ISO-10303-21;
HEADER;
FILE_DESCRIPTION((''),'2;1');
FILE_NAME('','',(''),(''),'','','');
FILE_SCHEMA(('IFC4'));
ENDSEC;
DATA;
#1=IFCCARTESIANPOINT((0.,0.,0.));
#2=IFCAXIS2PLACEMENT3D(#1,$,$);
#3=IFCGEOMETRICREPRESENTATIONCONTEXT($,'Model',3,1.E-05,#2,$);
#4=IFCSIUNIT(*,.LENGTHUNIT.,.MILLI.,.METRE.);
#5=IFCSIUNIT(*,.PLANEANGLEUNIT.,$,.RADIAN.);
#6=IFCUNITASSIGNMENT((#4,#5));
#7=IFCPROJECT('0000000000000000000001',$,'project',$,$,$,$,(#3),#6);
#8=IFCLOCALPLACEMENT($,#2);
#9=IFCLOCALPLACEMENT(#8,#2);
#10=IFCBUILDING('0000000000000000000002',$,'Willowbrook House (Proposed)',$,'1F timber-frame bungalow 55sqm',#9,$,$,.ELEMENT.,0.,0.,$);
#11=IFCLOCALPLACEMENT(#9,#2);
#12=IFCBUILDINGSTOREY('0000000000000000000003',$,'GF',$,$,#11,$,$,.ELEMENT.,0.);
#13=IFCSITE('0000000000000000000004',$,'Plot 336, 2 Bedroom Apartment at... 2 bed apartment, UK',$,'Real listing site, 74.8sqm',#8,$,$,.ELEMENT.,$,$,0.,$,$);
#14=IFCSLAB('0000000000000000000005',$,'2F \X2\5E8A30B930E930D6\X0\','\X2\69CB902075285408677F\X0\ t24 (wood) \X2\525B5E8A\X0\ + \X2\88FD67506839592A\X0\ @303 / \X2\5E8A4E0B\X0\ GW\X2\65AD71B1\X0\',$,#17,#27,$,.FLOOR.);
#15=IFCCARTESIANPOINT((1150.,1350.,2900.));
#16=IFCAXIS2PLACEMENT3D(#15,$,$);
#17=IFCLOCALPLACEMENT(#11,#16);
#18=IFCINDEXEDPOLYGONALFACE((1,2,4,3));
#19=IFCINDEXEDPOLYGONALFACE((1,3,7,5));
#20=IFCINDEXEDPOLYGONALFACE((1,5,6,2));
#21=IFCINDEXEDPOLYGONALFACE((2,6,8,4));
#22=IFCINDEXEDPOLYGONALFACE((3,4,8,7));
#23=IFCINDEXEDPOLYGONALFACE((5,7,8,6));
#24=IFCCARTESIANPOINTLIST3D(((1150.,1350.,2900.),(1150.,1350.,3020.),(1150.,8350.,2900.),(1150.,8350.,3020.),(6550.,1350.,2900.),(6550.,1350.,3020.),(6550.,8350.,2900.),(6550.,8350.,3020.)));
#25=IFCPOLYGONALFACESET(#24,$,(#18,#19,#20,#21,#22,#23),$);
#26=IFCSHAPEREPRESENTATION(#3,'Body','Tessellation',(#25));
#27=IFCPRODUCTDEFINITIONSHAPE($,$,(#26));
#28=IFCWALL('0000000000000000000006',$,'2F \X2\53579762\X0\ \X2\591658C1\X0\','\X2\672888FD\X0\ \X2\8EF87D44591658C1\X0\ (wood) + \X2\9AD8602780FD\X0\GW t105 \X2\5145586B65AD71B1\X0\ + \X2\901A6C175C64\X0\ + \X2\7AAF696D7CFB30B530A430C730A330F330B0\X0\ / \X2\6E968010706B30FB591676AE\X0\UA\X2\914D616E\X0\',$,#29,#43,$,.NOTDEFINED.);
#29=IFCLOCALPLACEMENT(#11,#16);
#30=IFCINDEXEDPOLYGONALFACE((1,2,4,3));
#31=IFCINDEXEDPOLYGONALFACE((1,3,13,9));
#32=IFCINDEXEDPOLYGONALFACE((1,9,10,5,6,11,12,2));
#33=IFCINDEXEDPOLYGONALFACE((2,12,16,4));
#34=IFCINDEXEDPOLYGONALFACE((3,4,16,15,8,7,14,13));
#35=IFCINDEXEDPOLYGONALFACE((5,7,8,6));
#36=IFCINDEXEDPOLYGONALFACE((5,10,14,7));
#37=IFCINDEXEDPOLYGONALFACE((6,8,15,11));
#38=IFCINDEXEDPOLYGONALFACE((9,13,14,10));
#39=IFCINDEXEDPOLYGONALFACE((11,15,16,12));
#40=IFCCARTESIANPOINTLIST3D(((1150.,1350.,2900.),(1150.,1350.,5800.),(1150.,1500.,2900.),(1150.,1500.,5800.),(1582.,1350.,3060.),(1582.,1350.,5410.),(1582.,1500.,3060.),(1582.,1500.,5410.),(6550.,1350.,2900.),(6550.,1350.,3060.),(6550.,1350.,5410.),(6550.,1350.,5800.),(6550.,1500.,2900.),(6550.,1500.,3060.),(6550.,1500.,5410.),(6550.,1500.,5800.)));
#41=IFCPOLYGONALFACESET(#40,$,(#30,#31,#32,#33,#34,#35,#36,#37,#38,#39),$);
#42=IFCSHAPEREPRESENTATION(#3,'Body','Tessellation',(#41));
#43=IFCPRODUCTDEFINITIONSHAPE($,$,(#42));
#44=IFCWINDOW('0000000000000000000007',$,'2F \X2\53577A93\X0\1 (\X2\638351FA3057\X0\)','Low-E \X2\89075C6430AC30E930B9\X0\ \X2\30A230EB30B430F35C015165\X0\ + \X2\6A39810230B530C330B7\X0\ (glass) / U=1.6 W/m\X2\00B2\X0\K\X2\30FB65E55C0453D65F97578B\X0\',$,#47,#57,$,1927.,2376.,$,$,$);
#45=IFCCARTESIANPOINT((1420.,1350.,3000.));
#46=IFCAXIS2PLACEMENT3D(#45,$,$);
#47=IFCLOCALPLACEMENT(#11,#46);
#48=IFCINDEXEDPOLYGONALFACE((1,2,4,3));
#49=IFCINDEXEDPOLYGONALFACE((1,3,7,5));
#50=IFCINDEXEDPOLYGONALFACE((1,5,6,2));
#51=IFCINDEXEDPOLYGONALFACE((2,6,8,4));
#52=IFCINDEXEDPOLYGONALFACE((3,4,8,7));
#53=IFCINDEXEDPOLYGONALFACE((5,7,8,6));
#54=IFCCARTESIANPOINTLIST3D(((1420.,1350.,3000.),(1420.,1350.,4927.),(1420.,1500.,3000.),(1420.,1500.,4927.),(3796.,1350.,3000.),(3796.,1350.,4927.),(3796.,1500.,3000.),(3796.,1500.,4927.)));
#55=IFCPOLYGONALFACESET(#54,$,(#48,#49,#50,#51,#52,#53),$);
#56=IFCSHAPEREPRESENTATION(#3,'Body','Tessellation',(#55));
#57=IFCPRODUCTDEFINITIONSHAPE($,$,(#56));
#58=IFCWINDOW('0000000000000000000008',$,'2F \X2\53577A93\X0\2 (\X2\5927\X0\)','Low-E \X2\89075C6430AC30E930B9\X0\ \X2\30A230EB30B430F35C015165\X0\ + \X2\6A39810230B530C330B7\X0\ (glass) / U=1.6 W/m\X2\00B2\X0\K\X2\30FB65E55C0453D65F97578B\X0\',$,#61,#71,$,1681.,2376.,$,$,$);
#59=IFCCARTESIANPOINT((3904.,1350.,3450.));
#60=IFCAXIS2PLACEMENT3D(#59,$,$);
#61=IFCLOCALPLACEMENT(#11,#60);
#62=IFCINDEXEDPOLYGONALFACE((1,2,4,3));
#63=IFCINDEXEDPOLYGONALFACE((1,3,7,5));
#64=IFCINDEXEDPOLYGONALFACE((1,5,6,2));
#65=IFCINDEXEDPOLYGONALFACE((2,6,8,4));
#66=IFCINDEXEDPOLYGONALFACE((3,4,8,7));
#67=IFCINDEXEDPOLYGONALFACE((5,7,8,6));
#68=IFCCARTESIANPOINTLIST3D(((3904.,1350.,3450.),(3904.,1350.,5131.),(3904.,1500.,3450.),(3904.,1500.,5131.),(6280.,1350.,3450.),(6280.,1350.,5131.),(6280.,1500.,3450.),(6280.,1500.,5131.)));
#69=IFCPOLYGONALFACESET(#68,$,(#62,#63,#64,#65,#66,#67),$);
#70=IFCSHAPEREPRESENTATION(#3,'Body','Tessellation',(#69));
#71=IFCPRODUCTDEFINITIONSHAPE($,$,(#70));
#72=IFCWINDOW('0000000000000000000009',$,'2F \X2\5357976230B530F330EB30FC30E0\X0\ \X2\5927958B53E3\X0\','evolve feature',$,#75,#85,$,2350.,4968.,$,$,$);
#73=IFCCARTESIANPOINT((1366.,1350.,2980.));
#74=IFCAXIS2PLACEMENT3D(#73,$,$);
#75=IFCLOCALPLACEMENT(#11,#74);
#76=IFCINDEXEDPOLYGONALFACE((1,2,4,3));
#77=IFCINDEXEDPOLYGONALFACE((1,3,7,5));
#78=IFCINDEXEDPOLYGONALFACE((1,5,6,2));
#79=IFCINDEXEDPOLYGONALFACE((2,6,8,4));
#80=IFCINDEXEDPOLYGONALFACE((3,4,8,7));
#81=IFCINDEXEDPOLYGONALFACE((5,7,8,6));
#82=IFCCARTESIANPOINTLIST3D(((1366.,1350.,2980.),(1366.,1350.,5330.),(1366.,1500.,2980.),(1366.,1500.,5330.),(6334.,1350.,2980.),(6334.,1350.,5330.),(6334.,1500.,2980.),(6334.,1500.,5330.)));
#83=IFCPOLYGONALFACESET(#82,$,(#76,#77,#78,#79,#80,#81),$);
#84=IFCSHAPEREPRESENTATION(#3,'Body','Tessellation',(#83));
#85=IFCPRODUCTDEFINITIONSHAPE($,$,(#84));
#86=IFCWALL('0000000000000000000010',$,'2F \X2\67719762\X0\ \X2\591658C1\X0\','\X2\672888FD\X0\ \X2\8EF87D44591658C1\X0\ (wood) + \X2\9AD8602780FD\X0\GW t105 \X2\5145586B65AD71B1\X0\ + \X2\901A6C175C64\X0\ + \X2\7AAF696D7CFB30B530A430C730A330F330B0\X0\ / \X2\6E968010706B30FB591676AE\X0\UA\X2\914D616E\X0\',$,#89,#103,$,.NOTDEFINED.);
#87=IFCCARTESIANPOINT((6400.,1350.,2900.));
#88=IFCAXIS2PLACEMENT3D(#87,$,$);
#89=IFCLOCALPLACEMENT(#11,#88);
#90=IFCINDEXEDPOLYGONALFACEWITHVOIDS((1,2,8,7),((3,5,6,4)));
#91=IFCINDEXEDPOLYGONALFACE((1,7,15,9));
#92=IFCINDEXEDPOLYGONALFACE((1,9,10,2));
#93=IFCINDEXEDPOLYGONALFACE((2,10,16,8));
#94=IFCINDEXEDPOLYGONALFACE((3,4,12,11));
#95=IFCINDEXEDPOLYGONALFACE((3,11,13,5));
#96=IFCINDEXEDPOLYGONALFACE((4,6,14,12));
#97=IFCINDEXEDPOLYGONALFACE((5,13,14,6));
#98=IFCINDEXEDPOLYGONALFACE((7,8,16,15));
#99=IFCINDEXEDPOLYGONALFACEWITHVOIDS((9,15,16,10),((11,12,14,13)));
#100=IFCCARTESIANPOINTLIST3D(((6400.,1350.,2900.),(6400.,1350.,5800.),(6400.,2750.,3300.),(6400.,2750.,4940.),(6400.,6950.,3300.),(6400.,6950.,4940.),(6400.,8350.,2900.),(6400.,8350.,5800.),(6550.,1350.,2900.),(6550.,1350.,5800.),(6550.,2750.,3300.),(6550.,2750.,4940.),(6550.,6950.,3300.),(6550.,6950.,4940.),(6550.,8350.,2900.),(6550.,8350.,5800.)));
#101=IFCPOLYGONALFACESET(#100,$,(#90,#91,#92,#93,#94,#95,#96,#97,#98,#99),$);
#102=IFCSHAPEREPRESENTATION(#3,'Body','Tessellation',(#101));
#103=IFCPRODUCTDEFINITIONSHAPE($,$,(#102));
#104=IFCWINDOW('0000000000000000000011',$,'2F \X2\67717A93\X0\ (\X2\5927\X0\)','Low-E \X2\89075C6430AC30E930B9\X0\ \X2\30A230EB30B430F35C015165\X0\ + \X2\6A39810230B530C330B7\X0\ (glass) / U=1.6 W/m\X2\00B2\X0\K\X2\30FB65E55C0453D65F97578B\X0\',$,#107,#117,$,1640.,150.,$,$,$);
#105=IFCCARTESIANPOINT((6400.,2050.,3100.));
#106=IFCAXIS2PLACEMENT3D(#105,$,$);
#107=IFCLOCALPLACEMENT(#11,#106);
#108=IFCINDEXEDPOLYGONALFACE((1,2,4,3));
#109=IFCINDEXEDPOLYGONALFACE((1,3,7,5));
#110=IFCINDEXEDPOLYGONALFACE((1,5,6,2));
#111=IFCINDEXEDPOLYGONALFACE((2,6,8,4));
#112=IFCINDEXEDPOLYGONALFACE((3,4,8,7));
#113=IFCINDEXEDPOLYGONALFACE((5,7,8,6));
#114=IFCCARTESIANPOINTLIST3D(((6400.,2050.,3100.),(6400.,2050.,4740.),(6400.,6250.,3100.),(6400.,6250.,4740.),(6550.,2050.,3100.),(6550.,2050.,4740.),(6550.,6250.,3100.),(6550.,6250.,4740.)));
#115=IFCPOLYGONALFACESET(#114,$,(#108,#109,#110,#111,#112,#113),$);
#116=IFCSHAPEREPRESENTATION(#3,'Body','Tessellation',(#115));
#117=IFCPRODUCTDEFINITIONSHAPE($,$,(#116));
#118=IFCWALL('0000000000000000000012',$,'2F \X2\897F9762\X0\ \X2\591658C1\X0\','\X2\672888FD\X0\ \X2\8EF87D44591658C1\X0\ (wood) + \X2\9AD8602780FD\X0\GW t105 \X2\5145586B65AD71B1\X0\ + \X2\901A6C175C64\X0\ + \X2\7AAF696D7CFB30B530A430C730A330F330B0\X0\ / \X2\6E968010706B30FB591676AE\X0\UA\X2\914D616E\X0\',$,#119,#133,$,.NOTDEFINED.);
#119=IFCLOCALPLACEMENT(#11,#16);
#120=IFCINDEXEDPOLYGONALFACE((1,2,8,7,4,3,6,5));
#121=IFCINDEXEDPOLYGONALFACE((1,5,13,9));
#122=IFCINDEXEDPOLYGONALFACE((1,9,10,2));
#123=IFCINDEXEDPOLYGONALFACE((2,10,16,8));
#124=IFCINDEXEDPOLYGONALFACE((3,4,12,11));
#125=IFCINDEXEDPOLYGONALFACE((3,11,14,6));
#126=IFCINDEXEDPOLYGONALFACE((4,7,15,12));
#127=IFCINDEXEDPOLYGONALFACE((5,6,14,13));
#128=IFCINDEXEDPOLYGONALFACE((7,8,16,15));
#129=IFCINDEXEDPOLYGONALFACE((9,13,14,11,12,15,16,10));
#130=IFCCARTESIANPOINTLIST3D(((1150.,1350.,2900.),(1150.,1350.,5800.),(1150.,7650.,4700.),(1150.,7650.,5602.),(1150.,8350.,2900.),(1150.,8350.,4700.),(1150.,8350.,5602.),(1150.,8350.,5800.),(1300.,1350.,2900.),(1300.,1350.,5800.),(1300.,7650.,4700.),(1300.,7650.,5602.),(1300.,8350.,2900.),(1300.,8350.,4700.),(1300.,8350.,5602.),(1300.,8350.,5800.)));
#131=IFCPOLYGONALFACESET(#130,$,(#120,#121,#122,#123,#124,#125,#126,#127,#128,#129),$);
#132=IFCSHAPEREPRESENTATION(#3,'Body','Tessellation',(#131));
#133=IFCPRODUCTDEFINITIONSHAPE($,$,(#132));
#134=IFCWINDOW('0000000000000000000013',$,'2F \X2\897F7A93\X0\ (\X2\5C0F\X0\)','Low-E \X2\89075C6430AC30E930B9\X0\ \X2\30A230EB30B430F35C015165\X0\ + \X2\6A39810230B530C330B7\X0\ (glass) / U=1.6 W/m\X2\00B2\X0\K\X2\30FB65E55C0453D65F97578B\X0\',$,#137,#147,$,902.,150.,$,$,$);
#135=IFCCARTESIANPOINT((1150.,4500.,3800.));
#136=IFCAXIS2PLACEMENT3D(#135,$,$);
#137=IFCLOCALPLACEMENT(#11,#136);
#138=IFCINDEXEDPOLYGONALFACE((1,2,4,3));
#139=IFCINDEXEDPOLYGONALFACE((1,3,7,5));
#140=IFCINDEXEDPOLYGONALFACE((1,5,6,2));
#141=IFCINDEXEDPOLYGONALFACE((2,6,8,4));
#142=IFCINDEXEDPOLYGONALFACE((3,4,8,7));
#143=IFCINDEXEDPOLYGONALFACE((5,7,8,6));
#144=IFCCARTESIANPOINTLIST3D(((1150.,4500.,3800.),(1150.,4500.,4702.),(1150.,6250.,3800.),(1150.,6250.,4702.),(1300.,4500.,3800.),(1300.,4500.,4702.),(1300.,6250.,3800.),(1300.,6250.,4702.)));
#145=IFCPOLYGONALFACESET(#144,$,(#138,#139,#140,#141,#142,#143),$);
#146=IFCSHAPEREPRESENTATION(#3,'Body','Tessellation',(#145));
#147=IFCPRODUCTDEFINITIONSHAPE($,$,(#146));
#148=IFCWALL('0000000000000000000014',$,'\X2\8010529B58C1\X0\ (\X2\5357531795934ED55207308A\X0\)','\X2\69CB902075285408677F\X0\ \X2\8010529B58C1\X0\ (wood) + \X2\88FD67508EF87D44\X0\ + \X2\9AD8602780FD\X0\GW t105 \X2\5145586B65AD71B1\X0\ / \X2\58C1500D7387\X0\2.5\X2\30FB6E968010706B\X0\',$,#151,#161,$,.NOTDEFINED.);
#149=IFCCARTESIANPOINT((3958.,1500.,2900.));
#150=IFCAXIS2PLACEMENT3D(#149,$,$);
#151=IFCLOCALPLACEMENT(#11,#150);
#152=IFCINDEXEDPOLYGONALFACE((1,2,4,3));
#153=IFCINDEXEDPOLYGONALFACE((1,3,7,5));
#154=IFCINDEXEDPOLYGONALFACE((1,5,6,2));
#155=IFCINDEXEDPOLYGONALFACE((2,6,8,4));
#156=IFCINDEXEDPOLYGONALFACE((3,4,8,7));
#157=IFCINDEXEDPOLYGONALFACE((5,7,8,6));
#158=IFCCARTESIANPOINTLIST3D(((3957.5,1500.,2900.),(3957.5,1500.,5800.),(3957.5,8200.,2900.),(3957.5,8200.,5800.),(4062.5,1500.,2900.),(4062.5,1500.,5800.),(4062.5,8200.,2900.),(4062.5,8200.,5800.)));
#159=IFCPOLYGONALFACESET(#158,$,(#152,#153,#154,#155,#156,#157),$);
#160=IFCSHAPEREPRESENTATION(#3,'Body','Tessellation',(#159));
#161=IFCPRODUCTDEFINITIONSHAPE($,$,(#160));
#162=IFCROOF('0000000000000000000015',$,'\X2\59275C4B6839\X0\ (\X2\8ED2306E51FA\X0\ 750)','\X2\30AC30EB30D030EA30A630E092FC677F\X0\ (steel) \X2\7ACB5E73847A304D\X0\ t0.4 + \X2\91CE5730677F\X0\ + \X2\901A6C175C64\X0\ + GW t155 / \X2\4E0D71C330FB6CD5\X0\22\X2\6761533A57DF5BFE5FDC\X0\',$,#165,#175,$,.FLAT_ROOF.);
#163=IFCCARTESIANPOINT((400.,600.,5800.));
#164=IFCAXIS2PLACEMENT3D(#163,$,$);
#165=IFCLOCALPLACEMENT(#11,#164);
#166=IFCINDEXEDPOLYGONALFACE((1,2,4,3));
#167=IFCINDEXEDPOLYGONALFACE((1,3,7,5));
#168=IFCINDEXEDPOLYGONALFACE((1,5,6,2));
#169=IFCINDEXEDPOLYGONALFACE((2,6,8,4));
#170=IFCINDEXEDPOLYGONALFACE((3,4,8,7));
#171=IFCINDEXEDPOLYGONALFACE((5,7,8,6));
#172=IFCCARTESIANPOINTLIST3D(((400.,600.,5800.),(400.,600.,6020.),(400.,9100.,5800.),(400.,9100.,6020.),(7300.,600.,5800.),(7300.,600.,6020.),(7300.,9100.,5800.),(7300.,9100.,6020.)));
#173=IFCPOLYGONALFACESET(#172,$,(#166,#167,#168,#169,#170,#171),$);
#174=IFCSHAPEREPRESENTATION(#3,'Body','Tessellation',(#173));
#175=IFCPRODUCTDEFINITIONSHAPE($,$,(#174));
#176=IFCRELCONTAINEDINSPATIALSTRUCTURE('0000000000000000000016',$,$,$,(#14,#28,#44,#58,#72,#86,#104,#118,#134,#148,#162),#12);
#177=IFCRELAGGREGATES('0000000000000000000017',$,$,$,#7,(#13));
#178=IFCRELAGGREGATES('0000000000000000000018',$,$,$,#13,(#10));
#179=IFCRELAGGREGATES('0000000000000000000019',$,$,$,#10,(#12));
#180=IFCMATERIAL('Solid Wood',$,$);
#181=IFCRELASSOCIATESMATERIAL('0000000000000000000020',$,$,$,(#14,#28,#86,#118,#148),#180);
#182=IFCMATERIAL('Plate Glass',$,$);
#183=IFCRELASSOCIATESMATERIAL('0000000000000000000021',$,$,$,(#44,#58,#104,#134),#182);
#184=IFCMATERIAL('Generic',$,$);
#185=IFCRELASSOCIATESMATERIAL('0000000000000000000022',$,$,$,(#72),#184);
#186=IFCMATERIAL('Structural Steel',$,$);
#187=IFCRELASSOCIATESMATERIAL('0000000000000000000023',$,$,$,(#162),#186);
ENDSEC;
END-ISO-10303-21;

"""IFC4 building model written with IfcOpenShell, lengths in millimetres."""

from ifc_helpers import new_model, si_unit, frame, frame_2d, origin, place, context, project, spatial, rectangle, extrude, material, element, fill, save


model = new_model("IFC4")

# Units and contexts
model_context = context("Model", 3, precision=1e-05, world=origin())
ifc_project = project(units=[si_unit("LENGTHUNIT", "METRE", prefix="MILLI"), si_unit("PLANEANGLEUNIT", "RADIAN")], contexts=[model_context])

# Site, building, storey
site_placement = place(None, origin())
site = spatial("IfcSite", under=ifc_project, at=site_placement, Name="Plot 336, 2 Bedroom Apartment at... 2 bed apartment, UK", ObjectType="Real listing site, 74.8sqm", CompositionType="ELEMENT", RefElevation=0.0)
building_placement = place(site_placement, origin())
building = spatial("IfcBuilding", under=site, at=building_placement, Name="Willowbrook House (Proposed)", ObjectType="1F timber-frame bungalow 55sqm", CompositionType="ELEMENT", ElevationOfRefHeight=0.0, ElevationOfTerrain=0.0)
storey_placement = place(building_placement, origin())
storey = spatial("IfcBuildingStorey", under=building, at=storey_placement, Name="GF", CompositionType="ELEMENT", Elevation=0.0)

# Slab
ifc_material_1 = material(Name="Solid Wood")
slab_placement = place(storey_placement, frame((1150.0, 1350.0, 2900.0)))
element("IfcSlab", 1, at=slab_placement, inside=storey, material=ifc_material_1, Name="2F 床スラブ", Description="構造用合板 t24 (wood) 剛床 + 製材根太 @303 / 床下 GW断熱", PredefinedType="FLOOR", context=model_context, shape_type="SweptSolid", body=[
    extrude(rectangle(XDim=5400.0, YDim=7000.0, at=frame_2d((2700.0, 3500.0))), frame((1150.0, 1350.0, 2900.0)), (0.0, 0.0, 1.0), 120.0),
])

# Wall, openings, windows
wall_1_placement = place(storey_placement, frame((1150.0, 1350.0, 2900.0)))
wall_1 = element("IfcWall", 2, at=wall_1_placement, inside=storey, material=ifc_material_1, Name="2F 南面 外壁", Description="木製 軸組外壁 (wood) + 高性能GW t105 充填断熱 + 通気層 + 窯業系サイディング / 準耐火・外皮UA配慮", PredefinedType="NOTDEFINED", context=model_context, shape_type="SweptSolid", body=[
    extrude(rectangle(XDim=5400.0, YDim=150.0, at=frame_2d((2700.0, 75.0))), frame((1150.0, 1350.0, 2900.0)), (0.0, 0.0, 1.0), 2900.0),
])
opening_1_placement = place(storey_placement, frame((1420.0, 1350.0, 3000.0)))
opening_1 = element("IfcOpeningElement", 3, at=opening_1_placement, cuts=wall_1, PredefinedType="NOTDEFINED", context=model_context, shape_type="SweptSolid", body=[
    extrude(rectangle(XDim=2376.0, YDim=150.0, at=frame_2d((1188.0, 75.0))), frame((1420.0, 1350.0, 3000.0)), (0.0, 0.0, 1.0), 1927.0),
])
opening_2_placement = place(storey_placement, frame((3904.0, 1350.0, 3450.0)))
opening_2 = element("IfcOpeningElement", 4, at=opening_2_placement, cuts=wall_1, PredefinedType="NOTDEFINED", context=model_context, shape_type="SweptSolid", body=[
    extrude(rectangle(XDim=2376.0, YDim=150.0, at=frame_2d((1188.0, 75.0))), frame((3904.0, 1350.0, 3450.0)), (0.0, 0.0, 1.0), 1681.0),
])
opening_3_placement = place(storey_placement, frame((1366.0, 1350.0, 2980.0)))
opening_3 = element("IfcOpeningElement", 5, at=opening_3_placement, cuts=wall_1, PredefinedType="NOTDEFINED", context=model_context, shape_type="SweptSolid", body=[
    extrude(rectangle(XDim=4968.0, YDim=150.0, at=frame_2d((2484.0, 75.0))), frame((1366.0, 1350.0, 2980.0)), (0.0, 0.0, 1.0), 2350.0),
])
ifc_material_2 = material(Name="Plate Glass")
window_1_placement = place(storey_placement, frame((1420.0, 1350.0, 3000.0)))
window_1 = element("IfcWindow", 6, at=window_1_placement, inside=storey, material=ifc_material_2, Name="2F 南窓1 (掃出し)", Description="Low-E 複層ガラス アルゴン封入 + 樹脂サッシ (glass) / U=1.6 W/m²K・日射取得型", OverallHeight=1927.0, OverallWidth=2376.0, context=model_context, shape_type="SweptSolid", body=[
    extrude(rectangle(XDim=2376.0, YDim=150.0, at=frame_2d((1188.0, 75.0))), frame((1420.0, 1350.0, 3000.0)), (0.0, 0.0, 1.0), 1927.0),
])
fill(opening_1, window_1)
window_2_placement = place(storey_placement, frame((3904.0, 1350.0, 3450.0)))
window_2 = element("IfcWindow", 7, at=window_2_placement, inside=storey, material=ifc_material_2, Name="2F 南窓2 (大)", Description="Low-E 複層ガラス アルゴン封入 + 樹脂サッシ (glass) / U=1.6 W/m²K・日射取得型", OverallHeight=1681.0, OverallWidth=2376.0, context=model_context, shape_type="SweptSolid", body=[
    extrude(rectangle(XDim=2376.0, YDim=150.0, at=frame_2d((1188.0, 75.0))), frame((3904.0, 1350.0, 3450.0)), (0.0, 0.0, 1.0), 1681.0),
])
fill(opening_2, window_2)
ifc_material_3 = material(Name="Generic")
window_3_placement = place(storey_placement, frame((1366.0, 1350.0, 2980.0)))
window_3 = element("IfcWindow", 8, at=window_3_placement, inside=storey, material=ifc_material_3, Name="2F 南面サンルーム 大開口", Description="evolve feature", OverallHeight=2350.0, OverallWidth=4968.0, context=model_context, shape_type="SweptSolid", body=[
    extrude(rectangle(XDim=4968.0, YDim=150.0, at=frame_2d((2484.0, 75.0))), frame((1366.0, 1350.0, 2980.0)), (0.0, 0.0, 1.0), 2350.0),
])
fill(opening_3, window_3)

# Walls, openings, windows
wall_2_placement = place(storey_placement, frame((6400.0, 1350.0, 2900.0)))
wall_2 = element("IfcWall", 9, at=wall_2_placement, inside=storey, material=ifc_material_1, Name="2F 東面 外壁", Description="木製 軸組外壁 (wood) + 高性能GW t105 充填断熱 + 通気層 + 窯業系サイディング / 準耐火・外皮UA配慮", PredefinedType="NOTDEFINED", context=model_context, shape_type="SweptSolid", body=[
    extrude(rectangle(XDim=150.0, YDim=7000.0, at=frame_2d((75.0, 3500.0))), frame((6400.0, 1350.0, 2900.0)), (0.0, 0.0, 1.0), 2900.0),
])
opening_4_placement = place(storey_placement, frame((6400.0, 2050.0, 3100.0)))
opening_4 = element("IfcOpeningElement", 10, at=opening_4_placement, cuts=wall_2, PredefinedType="NOTDEFINED", context=model_context, shape_type="SweptSolid", body=[
    extrude(rectangle(XDim=150.0, YDim=4200.0, at=frame_2d((75.0, 2100.0))), frame((6400.0, 2050.0, 3100.0)), (0.0, 0.0, 1.0), 1640.0),
])
window_4_placement = place(storey_placement, frame((6400.0, 2050.0, 3100.0)))
window_4 = element("IfcWindow", 11, at=window_4_placement, inside=storey, material=ifc_material_2, Name="2F 東窓 (大)", Description="Low-E 複層ガラス アルゴン封入 + 樹脂サッシ (glass) / U=1.6 W/m²K・日射取得型", OverallHeight=1640.0, OverallWidth=150.0, context=model_context, shape_type="SweptSolid", body=[
    extrude(rectangle(XDim=150.0, YDim=4200.0, at=frame_2d((75.0, 2100.0))), frame((6400.0, 2050.0, 3100.0)), (0.0, 0.0, 1.0), 1640.0),
])
fill(opening_4, window_4)
wall_3_placement = place(storey_placement, frame((1150.0, 1350.0, 2900.0)))
wall_3 = element("IfcWall", 12, at=wall_3_placement, inside=storey, material=ifc_material_1, Name="2F 西面 外壁", Description="木製 軸組外壁 (wood) + 高性能GW t105 充填断熱 + 通気層 + 窯業系サイディング / 準耐火・外皮UA配慮", PredefinedType="NOTDEFINED", context=model_context, shape_type="SweptSolid", body=[
    extrude(rectangle(XDim=150.0, YDim=7000.0, at=frame_2d((75.0, 3500.0))), frame((1150.0, 1350.0, 2900.0)), (0.0, 0.0, 1.0), 2900.0),
])
opening_5_placement = place(storey_placement, frame((1150.0, 4500.0, 3800.0)))
opening_5 = element("IfcOpeningElement", 13, at=opening_5_placement, cuts=wall_3, PredefinedType="NOTDEFINED", context=model_context, shape_type="SweptSolid", body=[
    extrude(rectangle(XDim=150.0, YDim=1750.0, at=frame_2d((75.0, 875.0))), frame((1150.0, 4500.0, 3800.0)), (0.0, 0.0, 1.0), 902.0),
])
window_5_placement = place(storey_placement, frame((1150.0, 4500.0, 3800.0)))
window_5 = element("IfcWindow", 14, at=window_5_placement, inside=storey, material=ifc_material_2, Name="2F 西窓 (小)", Description="Low-E 複層ガラス アルゴン封入 + 樹脂サッシ (glass) / U=1.6 W/m²K・日射取得型", OverallHeight=902.0, OverallWidth=150.0, context=model_context, shape_type="SweptSolid", body=[
    extrude(rectangle(XDim=150.0, YDim=1750.0, at=frame_2d((75.0, 875.0))), frame((1150.0, 4500.0, 3800.0)), (0.0, 0.0, 1.0), 902.0),
])
fill(opening_5, window_5)

# Wall
wall_4_placement = place(storey_placement, frame((3958.0, 1500.0, 2900.0)))
element("IfcWall", 15, at=wall_4_placement, inside=storey, material=ifc_material_1, Name="耐力壁 (南北間仕切り)", Description="構造用合板 耐力壁 (wood) + 製材軸組 + 高性能GW t105 充填断熱 / 壁倍率2.5・準耐火", PredefinedType="NOTDEFINED", context=model_context, shape_type="SweptSolid", body=[
    extrude(rectangle(XDim=105.0, YDim=6700.0, at=frame_2d((52.0, 3350.0))), frame((3958.0, 1500.0, 2900.0)), (0.0, 0.0, 1.0), 2900.0),
])

# Roof
ifc_material_4 = material(Name="Structural Steel")
roof_placement = place(storey_placement, frame((400.0, 600.0, 5800.0)))
element("IfcRoof", 16, at=roof_placement, inside=storey, material=ifc_material_4, Name="大屋根 (軒の出 750)", Description="ガルバリウム鋼板 (steel) 立平葺き t0.4 + 野地板 + 通気層 + GW t155 / 不燃・法22条区域対応", PredefinedType="FLAT_ROOF", context=model_context, shape_type="SweptSolid", body=[
    extrude(rectangle(XDim=6900.0, YDim=8500.0, at=frame_2d((3450.0, 4250.0))), frame((400.0, 600.0, 5800.0)), (0.0, 0.0, 1.0), 220.0),
])

save(model, "model.ifc")
